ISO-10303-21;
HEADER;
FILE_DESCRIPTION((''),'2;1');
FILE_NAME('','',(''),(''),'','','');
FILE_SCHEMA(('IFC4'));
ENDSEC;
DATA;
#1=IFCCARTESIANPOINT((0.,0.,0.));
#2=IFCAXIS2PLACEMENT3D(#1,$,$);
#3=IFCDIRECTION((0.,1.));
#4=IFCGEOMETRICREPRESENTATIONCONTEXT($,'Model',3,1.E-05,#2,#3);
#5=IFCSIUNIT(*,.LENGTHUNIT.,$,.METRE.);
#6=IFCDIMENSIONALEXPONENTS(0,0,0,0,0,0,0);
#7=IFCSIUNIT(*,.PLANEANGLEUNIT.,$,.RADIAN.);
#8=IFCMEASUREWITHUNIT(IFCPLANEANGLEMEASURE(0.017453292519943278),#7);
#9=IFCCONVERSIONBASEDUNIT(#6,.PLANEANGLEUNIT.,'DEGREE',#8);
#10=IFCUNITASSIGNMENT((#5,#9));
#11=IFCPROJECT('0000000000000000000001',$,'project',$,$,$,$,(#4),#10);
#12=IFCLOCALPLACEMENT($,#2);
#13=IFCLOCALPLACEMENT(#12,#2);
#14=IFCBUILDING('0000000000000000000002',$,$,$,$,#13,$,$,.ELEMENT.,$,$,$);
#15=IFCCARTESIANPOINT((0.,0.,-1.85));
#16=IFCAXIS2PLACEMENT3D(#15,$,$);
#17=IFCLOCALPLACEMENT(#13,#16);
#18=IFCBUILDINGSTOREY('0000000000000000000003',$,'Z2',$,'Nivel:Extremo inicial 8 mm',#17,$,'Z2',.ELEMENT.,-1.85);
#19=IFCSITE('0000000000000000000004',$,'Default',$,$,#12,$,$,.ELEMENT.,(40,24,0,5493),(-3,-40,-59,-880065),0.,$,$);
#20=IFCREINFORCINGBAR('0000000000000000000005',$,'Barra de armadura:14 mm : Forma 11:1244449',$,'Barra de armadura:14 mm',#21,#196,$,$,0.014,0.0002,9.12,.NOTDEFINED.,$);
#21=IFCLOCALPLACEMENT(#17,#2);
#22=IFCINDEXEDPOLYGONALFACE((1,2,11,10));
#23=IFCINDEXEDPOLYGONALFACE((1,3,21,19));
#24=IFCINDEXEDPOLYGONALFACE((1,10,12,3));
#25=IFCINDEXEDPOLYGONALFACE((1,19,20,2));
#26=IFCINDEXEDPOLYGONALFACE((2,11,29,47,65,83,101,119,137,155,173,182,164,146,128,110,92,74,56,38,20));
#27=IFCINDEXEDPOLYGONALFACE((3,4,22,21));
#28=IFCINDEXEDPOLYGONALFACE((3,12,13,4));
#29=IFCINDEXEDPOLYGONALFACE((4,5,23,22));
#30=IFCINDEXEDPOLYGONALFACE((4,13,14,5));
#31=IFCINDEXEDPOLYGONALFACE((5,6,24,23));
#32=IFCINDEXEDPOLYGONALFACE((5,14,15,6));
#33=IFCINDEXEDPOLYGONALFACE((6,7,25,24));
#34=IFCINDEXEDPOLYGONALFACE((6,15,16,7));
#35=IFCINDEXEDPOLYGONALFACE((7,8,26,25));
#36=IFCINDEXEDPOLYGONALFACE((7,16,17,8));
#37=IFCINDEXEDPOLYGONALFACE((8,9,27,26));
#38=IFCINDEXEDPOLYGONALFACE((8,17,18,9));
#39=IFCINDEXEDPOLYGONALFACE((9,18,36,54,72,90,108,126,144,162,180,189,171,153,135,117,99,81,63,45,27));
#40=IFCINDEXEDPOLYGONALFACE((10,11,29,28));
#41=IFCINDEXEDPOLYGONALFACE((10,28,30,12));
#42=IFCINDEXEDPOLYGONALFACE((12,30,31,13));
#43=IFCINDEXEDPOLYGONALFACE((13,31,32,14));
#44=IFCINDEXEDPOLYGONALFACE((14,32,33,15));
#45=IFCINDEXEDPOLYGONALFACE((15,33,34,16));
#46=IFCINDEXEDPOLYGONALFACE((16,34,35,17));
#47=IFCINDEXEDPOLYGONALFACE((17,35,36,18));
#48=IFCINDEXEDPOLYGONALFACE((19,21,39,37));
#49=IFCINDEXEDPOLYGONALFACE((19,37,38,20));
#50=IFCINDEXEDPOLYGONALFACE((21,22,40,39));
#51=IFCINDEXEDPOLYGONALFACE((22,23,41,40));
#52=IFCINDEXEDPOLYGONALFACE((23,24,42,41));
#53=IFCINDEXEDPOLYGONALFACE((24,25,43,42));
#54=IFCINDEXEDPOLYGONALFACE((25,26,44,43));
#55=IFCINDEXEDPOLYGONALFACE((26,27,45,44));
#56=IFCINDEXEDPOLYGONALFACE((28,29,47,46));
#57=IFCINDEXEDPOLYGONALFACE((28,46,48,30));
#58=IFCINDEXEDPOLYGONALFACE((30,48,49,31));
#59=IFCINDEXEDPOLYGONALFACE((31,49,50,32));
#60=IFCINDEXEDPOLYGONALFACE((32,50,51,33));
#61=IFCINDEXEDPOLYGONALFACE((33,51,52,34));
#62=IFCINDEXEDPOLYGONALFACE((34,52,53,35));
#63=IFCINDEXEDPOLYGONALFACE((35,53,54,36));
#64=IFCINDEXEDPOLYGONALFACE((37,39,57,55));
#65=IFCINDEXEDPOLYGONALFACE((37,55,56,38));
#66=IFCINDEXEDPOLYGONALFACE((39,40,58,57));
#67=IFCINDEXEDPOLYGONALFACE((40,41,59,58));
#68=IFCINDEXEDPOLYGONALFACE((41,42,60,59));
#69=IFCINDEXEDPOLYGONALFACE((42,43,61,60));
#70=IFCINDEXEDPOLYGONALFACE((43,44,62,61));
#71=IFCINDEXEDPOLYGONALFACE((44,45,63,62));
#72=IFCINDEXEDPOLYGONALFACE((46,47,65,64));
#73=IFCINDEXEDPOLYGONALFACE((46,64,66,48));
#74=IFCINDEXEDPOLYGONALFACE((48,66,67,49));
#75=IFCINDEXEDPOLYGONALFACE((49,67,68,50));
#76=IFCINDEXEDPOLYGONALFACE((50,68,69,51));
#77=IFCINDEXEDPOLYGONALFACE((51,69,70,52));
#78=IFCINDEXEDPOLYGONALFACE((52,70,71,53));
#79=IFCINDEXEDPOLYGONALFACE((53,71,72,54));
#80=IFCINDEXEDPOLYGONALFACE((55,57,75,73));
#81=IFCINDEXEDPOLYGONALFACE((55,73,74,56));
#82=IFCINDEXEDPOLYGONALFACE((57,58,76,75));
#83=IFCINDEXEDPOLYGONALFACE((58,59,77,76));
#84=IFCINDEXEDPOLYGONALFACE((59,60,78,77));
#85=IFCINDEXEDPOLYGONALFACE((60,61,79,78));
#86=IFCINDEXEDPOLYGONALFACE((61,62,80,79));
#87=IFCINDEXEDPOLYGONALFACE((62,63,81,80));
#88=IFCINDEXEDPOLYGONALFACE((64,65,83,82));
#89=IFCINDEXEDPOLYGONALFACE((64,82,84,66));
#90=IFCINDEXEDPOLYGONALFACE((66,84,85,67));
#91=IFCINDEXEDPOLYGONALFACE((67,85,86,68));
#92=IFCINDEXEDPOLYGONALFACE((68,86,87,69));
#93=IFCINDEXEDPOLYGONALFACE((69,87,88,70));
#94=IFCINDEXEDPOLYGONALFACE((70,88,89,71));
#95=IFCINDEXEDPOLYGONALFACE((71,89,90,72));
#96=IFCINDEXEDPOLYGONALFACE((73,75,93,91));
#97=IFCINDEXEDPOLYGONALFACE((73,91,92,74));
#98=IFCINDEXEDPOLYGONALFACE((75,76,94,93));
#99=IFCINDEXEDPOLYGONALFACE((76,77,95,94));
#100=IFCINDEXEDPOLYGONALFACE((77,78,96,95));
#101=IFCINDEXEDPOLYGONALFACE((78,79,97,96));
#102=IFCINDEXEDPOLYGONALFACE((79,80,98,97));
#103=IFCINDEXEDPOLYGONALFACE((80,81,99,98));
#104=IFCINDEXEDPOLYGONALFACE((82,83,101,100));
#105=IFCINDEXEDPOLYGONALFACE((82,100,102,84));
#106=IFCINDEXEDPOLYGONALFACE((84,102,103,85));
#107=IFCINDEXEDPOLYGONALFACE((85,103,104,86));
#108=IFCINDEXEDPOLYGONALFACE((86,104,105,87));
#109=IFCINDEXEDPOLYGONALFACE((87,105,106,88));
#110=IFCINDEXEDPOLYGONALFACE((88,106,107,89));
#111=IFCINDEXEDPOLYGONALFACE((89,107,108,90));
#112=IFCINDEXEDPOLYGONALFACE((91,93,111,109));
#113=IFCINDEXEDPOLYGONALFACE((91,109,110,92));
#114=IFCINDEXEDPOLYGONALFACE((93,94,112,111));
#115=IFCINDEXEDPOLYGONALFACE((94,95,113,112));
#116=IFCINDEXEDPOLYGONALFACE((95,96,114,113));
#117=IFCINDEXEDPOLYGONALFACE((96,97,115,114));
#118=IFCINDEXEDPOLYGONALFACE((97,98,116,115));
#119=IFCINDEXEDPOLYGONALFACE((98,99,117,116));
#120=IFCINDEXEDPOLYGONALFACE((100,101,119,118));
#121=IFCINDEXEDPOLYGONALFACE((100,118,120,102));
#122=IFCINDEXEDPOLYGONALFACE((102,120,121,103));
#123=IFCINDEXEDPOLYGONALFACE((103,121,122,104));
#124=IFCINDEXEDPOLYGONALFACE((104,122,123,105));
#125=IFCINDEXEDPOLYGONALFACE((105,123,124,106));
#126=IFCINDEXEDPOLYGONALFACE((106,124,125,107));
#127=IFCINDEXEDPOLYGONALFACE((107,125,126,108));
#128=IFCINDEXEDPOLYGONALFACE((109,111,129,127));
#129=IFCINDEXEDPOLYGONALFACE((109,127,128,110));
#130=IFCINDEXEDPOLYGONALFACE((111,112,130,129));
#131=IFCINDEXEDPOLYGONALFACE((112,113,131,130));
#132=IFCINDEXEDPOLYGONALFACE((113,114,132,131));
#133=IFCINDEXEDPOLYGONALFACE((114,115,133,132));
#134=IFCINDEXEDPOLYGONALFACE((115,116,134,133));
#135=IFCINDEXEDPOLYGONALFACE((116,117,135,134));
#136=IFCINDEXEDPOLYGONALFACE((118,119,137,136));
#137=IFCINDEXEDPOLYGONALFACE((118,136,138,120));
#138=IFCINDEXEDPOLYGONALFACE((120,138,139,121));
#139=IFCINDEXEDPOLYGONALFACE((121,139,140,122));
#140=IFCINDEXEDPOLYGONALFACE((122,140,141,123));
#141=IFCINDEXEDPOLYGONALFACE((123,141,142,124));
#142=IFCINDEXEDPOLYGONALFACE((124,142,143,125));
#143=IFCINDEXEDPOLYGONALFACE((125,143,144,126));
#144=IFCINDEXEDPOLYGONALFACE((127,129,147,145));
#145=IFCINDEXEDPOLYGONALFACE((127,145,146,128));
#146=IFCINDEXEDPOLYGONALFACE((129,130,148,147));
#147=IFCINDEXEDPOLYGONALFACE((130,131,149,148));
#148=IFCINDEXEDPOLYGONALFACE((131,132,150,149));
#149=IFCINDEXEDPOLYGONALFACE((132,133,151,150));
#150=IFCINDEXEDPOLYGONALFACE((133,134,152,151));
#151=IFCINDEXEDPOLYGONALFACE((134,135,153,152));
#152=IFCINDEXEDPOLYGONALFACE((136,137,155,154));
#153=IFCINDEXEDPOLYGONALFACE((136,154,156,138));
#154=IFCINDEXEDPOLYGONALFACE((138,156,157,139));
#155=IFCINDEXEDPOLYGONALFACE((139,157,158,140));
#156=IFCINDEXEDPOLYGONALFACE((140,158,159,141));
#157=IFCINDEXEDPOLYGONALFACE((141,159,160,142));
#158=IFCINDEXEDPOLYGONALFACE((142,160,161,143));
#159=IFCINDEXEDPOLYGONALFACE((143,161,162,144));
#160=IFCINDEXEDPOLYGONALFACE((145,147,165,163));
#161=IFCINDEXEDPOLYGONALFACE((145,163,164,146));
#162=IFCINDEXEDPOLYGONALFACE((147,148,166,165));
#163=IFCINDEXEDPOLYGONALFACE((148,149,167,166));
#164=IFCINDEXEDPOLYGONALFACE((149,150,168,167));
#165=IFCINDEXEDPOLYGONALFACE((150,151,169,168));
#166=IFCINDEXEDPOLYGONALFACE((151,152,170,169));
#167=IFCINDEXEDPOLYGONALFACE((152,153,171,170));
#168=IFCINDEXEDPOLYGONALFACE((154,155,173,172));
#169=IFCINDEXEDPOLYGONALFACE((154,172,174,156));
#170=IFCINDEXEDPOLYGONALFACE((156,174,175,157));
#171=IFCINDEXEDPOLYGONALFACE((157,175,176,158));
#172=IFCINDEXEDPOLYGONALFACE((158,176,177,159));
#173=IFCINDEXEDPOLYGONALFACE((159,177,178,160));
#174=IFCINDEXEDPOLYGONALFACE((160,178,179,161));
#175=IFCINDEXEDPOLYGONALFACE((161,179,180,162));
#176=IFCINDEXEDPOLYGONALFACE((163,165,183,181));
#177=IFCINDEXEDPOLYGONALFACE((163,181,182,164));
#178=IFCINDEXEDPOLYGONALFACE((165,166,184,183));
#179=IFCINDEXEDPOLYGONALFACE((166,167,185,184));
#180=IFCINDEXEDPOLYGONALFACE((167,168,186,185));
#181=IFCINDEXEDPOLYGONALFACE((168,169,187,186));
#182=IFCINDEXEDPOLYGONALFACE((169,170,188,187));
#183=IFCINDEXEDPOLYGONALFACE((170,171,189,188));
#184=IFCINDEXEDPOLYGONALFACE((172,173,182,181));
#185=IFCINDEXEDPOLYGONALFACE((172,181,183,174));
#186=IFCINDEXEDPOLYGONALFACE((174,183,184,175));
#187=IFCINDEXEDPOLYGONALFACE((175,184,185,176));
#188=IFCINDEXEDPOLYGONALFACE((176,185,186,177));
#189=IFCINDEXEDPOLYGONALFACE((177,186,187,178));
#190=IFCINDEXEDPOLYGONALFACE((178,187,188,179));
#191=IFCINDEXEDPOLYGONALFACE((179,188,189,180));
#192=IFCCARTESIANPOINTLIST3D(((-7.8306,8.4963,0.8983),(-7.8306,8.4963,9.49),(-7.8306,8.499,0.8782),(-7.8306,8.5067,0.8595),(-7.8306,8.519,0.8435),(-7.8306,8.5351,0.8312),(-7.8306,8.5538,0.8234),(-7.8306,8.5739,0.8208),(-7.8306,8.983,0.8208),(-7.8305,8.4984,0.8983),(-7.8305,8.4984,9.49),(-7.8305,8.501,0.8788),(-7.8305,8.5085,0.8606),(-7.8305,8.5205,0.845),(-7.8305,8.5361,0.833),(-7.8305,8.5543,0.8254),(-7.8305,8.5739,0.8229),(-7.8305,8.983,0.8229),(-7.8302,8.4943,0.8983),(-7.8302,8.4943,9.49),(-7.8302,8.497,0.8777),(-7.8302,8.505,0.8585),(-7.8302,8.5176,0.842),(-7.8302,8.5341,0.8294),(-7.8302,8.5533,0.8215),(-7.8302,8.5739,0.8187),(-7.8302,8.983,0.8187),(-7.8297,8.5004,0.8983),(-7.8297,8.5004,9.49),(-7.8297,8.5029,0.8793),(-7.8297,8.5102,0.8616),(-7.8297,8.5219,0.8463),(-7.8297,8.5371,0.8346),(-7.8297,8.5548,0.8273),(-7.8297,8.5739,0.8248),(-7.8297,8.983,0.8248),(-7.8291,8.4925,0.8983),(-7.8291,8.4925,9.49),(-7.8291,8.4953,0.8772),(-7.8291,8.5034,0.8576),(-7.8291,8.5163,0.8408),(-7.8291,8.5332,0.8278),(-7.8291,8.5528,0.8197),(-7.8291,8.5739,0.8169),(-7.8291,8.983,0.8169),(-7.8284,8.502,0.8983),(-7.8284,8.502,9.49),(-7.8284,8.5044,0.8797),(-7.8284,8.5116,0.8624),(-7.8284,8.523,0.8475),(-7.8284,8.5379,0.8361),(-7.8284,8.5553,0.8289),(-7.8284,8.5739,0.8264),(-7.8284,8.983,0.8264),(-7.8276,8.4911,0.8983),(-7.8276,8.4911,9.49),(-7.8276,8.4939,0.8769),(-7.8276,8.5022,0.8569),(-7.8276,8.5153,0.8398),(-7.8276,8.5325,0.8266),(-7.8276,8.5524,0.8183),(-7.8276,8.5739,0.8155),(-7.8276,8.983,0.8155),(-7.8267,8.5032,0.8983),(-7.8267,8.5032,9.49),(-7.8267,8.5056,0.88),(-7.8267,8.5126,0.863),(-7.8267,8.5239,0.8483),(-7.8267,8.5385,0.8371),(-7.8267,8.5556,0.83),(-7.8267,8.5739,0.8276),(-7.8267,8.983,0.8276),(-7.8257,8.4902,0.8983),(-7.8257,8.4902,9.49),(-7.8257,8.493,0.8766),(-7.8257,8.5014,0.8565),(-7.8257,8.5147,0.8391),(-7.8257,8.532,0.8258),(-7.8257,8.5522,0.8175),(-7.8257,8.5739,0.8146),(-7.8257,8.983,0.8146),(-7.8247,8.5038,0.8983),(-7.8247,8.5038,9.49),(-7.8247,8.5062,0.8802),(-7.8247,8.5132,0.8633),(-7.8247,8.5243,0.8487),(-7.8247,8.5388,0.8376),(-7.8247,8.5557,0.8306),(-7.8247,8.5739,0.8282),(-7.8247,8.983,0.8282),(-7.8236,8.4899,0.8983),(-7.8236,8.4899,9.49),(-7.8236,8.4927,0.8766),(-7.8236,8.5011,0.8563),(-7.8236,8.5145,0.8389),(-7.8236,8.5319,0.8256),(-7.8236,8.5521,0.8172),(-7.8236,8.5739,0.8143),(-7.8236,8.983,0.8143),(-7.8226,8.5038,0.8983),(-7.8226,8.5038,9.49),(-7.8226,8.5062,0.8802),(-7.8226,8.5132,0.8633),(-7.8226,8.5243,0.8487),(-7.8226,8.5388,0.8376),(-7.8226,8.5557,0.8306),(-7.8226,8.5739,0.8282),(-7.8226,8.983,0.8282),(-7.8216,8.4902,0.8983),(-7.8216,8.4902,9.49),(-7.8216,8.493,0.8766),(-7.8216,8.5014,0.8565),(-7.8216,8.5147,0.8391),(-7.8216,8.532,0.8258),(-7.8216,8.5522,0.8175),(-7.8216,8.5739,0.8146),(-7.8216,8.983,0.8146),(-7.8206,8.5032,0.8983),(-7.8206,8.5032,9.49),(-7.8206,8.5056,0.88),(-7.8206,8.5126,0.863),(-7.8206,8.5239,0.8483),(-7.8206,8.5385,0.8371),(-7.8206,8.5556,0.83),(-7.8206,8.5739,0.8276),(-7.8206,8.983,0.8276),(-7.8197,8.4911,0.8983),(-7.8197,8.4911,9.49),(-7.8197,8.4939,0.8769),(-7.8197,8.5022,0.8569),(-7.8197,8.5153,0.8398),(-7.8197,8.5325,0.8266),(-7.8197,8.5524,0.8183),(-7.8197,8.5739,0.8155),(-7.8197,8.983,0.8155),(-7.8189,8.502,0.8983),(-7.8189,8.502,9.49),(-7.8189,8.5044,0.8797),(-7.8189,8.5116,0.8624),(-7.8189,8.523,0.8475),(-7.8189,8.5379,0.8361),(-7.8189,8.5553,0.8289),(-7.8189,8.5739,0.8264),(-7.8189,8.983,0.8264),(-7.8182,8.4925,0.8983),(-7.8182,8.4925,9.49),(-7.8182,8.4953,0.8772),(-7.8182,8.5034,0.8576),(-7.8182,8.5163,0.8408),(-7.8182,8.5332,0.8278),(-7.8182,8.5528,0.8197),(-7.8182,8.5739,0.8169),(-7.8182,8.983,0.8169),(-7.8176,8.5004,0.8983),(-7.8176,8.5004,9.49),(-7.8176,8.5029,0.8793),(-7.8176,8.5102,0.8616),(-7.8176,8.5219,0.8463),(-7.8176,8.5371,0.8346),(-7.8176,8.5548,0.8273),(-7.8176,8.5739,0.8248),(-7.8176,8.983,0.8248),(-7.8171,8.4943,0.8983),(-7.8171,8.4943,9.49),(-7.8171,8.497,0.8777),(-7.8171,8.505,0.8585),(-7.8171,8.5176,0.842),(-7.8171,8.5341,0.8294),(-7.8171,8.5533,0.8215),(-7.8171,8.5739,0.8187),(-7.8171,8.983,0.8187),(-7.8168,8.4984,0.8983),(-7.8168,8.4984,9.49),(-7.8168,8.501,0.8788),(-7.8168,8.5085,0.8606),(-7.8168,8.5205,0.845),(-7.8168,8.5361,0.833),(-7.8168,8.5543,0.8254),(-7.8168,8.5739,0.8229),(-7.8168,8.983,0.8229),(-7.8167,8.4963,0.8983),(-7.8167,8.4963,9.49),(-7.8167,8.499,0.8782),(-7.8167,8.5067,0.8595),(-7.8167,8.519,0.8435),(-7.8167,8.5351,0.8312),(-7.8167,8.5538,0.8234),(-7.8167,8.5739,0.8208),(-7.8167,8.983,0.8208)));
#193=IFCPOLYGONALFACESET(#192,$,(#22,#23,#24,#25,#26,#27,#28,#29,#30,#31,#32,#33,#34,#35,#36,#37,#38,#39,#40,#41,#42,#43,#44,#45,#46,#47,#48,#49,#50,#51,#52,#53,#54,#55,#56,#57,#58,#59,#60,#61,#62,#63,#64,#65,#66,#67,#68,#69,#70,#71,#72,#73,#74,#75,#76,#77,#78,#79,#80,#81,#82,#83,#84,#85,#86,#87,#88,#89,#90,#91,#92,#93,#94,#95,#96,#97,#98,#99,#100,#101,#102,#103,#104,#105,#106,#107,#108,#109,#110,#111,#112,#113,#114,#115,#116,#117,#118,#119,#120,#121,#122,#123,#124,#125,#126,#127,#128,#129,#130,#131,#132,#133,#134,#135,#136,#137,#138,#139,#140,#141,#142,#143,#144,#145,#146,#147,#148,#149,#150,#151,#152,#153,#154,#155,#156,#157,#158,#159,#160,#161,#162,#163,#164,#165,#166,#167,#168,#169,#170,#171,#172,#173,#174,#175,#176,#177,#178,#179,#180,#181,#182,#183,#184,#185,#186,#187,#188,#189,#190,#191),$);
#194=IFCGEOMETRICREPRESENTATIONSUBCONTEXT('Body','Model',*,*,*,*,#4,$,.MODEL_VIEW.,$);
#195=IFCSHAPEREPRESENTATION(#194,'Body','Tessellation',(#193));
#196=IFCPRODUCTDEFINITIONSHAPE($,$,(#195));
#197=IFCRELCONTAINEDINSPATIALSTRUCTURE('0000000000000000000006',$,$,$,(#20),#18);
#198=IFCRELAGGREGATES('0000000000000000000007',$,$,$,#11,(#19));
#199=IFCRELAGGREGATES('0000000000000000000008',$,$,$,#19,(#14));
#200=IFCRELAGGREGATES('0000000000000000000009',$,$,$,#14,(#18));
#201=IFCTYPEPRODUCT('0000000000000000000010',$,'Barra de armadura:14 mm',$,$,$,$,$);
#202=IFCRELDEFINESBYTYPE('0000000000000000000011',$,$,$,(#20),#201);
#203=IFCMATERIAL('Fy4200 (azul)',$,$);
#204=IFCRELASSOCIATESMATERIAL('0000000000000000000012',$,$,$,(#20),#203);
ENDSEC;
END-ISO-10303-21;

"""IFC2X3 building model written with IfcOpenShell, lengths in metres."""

from ifc_helpers import new_model, entity, si_unit, converted_unit, direction, frame, origin, place, context, subcontext, project, spatial, material, type_object, element, save


model = new_model("IFC2X3")

# Units and contexts
model_context = context("Model", 3, precision=1e-05, world=origin(), true_north=direction((0.0, 1.0)))
body_context = subcontext(model_context, "Body", "Model", "MODEL_VIEW")
ifc_project = project(units=[si_unit("LENGTHUNIT", "METRE"), converted_unit("PLANEANGLEUNIT", "DEGREE", entity("IfcPlaneAngleMeasure", 0.017453292519943278), si_unit("PLANEANGLEUNIT", "RADIAN"), dimensions=[0, 0, 0, 0, 0, 0, 0])], contexts=[model_context])

# Site, building, storey
site_placement = place(None, origin())
site = spatial("IfcSite", under=ifc_project, at=site_placement, Name="Default", CompositionType="ELEMENT", RefLatitude=(40, 24, 0, 5493), RefLongitude=(-3, -40, -59, -880065), RefElevation=0.0)
building_placement = place(site_placement, origin())
building = spatial("IfcBuilding", under=site, at=building_placement, CompositionType="ELEMENT")
storey_placement = place(building_placement, frame((0.0, 0.0, -1.85)))
storey = spatial("IfcBuildingStorey", under=building, at=storey_placement, Name="Z2", ObjectType="Nivel:Extremo inicial 8 mm", LongName="Z2", CompositionType="ELEMENT", Elevation=-1.85)

# Reinforcing bar
ifc_material_1 = material(Name="Fy4200 (azul)")
type_product_1 = type_object("IfcTypeProduct", Name="Barra de armadura:14 mm")
reinforcing_bar_1_placement = place(storey_placement, origin())
element("IfcReinforcingBar", 1, at=reinforcing_bar_1_placement, inside=storey, type_object=type_product_1, material=ifc_material_1, Name="Barra de armadura:14 mm : Forma 11:1244449", ObjectType="Barra de armadura:14 mm", BarLength=9.12, BarRole="NOTDEFINED", CrossSectionArea=0.0002, NominalDiameter=0.014, context=body_context, shape_type="AdvancedSweptSolid", body=[
    entity("IfcSweptDiskSolid", entity("IfcCompositeCurve", [entity("IfcCompositeCurveSegment", "CONTINUOUS", True, entity("IfcPolyline", [entity("IfcCartesianPoint", [-7.8236, 8.4969, 9.49]), entity("IfcCartesianPoint", [-7.8236, 8.4969, 0.8983])])), entity("IfcCompositeCurveSegment", "CONTINUOUS", True, entity("IfcTrimmedCurve", entity("IfcCircle", entity("IfcAxis2Placement3D", entity("IfcCartesianPoint", [-7.8236, 8.5739, 0.8983]), entity("IfcDirection", [1.0, 0.0, 0.0]), entity("IfcDirection", [0.0, 0.0, -1.0])), 0.077), [entity("IfcParameterValue", 270.0)], [entity("IfcParameterValue", 360.0)], True, "PARAMETER")), entity("IfcCompositeCurveSegment", "CONTINUOUS", True, entity("IfcPolyline", [entity("IfcCartesianPoint", [-7.8236, 8.5739, 0.8213]), entity("IfcCartesianPoint", [-7.8236, 8.983, 0.8213])]))], False), 0.007, None, 0.0, 92.0),
])

save(model, "model.ifc")
